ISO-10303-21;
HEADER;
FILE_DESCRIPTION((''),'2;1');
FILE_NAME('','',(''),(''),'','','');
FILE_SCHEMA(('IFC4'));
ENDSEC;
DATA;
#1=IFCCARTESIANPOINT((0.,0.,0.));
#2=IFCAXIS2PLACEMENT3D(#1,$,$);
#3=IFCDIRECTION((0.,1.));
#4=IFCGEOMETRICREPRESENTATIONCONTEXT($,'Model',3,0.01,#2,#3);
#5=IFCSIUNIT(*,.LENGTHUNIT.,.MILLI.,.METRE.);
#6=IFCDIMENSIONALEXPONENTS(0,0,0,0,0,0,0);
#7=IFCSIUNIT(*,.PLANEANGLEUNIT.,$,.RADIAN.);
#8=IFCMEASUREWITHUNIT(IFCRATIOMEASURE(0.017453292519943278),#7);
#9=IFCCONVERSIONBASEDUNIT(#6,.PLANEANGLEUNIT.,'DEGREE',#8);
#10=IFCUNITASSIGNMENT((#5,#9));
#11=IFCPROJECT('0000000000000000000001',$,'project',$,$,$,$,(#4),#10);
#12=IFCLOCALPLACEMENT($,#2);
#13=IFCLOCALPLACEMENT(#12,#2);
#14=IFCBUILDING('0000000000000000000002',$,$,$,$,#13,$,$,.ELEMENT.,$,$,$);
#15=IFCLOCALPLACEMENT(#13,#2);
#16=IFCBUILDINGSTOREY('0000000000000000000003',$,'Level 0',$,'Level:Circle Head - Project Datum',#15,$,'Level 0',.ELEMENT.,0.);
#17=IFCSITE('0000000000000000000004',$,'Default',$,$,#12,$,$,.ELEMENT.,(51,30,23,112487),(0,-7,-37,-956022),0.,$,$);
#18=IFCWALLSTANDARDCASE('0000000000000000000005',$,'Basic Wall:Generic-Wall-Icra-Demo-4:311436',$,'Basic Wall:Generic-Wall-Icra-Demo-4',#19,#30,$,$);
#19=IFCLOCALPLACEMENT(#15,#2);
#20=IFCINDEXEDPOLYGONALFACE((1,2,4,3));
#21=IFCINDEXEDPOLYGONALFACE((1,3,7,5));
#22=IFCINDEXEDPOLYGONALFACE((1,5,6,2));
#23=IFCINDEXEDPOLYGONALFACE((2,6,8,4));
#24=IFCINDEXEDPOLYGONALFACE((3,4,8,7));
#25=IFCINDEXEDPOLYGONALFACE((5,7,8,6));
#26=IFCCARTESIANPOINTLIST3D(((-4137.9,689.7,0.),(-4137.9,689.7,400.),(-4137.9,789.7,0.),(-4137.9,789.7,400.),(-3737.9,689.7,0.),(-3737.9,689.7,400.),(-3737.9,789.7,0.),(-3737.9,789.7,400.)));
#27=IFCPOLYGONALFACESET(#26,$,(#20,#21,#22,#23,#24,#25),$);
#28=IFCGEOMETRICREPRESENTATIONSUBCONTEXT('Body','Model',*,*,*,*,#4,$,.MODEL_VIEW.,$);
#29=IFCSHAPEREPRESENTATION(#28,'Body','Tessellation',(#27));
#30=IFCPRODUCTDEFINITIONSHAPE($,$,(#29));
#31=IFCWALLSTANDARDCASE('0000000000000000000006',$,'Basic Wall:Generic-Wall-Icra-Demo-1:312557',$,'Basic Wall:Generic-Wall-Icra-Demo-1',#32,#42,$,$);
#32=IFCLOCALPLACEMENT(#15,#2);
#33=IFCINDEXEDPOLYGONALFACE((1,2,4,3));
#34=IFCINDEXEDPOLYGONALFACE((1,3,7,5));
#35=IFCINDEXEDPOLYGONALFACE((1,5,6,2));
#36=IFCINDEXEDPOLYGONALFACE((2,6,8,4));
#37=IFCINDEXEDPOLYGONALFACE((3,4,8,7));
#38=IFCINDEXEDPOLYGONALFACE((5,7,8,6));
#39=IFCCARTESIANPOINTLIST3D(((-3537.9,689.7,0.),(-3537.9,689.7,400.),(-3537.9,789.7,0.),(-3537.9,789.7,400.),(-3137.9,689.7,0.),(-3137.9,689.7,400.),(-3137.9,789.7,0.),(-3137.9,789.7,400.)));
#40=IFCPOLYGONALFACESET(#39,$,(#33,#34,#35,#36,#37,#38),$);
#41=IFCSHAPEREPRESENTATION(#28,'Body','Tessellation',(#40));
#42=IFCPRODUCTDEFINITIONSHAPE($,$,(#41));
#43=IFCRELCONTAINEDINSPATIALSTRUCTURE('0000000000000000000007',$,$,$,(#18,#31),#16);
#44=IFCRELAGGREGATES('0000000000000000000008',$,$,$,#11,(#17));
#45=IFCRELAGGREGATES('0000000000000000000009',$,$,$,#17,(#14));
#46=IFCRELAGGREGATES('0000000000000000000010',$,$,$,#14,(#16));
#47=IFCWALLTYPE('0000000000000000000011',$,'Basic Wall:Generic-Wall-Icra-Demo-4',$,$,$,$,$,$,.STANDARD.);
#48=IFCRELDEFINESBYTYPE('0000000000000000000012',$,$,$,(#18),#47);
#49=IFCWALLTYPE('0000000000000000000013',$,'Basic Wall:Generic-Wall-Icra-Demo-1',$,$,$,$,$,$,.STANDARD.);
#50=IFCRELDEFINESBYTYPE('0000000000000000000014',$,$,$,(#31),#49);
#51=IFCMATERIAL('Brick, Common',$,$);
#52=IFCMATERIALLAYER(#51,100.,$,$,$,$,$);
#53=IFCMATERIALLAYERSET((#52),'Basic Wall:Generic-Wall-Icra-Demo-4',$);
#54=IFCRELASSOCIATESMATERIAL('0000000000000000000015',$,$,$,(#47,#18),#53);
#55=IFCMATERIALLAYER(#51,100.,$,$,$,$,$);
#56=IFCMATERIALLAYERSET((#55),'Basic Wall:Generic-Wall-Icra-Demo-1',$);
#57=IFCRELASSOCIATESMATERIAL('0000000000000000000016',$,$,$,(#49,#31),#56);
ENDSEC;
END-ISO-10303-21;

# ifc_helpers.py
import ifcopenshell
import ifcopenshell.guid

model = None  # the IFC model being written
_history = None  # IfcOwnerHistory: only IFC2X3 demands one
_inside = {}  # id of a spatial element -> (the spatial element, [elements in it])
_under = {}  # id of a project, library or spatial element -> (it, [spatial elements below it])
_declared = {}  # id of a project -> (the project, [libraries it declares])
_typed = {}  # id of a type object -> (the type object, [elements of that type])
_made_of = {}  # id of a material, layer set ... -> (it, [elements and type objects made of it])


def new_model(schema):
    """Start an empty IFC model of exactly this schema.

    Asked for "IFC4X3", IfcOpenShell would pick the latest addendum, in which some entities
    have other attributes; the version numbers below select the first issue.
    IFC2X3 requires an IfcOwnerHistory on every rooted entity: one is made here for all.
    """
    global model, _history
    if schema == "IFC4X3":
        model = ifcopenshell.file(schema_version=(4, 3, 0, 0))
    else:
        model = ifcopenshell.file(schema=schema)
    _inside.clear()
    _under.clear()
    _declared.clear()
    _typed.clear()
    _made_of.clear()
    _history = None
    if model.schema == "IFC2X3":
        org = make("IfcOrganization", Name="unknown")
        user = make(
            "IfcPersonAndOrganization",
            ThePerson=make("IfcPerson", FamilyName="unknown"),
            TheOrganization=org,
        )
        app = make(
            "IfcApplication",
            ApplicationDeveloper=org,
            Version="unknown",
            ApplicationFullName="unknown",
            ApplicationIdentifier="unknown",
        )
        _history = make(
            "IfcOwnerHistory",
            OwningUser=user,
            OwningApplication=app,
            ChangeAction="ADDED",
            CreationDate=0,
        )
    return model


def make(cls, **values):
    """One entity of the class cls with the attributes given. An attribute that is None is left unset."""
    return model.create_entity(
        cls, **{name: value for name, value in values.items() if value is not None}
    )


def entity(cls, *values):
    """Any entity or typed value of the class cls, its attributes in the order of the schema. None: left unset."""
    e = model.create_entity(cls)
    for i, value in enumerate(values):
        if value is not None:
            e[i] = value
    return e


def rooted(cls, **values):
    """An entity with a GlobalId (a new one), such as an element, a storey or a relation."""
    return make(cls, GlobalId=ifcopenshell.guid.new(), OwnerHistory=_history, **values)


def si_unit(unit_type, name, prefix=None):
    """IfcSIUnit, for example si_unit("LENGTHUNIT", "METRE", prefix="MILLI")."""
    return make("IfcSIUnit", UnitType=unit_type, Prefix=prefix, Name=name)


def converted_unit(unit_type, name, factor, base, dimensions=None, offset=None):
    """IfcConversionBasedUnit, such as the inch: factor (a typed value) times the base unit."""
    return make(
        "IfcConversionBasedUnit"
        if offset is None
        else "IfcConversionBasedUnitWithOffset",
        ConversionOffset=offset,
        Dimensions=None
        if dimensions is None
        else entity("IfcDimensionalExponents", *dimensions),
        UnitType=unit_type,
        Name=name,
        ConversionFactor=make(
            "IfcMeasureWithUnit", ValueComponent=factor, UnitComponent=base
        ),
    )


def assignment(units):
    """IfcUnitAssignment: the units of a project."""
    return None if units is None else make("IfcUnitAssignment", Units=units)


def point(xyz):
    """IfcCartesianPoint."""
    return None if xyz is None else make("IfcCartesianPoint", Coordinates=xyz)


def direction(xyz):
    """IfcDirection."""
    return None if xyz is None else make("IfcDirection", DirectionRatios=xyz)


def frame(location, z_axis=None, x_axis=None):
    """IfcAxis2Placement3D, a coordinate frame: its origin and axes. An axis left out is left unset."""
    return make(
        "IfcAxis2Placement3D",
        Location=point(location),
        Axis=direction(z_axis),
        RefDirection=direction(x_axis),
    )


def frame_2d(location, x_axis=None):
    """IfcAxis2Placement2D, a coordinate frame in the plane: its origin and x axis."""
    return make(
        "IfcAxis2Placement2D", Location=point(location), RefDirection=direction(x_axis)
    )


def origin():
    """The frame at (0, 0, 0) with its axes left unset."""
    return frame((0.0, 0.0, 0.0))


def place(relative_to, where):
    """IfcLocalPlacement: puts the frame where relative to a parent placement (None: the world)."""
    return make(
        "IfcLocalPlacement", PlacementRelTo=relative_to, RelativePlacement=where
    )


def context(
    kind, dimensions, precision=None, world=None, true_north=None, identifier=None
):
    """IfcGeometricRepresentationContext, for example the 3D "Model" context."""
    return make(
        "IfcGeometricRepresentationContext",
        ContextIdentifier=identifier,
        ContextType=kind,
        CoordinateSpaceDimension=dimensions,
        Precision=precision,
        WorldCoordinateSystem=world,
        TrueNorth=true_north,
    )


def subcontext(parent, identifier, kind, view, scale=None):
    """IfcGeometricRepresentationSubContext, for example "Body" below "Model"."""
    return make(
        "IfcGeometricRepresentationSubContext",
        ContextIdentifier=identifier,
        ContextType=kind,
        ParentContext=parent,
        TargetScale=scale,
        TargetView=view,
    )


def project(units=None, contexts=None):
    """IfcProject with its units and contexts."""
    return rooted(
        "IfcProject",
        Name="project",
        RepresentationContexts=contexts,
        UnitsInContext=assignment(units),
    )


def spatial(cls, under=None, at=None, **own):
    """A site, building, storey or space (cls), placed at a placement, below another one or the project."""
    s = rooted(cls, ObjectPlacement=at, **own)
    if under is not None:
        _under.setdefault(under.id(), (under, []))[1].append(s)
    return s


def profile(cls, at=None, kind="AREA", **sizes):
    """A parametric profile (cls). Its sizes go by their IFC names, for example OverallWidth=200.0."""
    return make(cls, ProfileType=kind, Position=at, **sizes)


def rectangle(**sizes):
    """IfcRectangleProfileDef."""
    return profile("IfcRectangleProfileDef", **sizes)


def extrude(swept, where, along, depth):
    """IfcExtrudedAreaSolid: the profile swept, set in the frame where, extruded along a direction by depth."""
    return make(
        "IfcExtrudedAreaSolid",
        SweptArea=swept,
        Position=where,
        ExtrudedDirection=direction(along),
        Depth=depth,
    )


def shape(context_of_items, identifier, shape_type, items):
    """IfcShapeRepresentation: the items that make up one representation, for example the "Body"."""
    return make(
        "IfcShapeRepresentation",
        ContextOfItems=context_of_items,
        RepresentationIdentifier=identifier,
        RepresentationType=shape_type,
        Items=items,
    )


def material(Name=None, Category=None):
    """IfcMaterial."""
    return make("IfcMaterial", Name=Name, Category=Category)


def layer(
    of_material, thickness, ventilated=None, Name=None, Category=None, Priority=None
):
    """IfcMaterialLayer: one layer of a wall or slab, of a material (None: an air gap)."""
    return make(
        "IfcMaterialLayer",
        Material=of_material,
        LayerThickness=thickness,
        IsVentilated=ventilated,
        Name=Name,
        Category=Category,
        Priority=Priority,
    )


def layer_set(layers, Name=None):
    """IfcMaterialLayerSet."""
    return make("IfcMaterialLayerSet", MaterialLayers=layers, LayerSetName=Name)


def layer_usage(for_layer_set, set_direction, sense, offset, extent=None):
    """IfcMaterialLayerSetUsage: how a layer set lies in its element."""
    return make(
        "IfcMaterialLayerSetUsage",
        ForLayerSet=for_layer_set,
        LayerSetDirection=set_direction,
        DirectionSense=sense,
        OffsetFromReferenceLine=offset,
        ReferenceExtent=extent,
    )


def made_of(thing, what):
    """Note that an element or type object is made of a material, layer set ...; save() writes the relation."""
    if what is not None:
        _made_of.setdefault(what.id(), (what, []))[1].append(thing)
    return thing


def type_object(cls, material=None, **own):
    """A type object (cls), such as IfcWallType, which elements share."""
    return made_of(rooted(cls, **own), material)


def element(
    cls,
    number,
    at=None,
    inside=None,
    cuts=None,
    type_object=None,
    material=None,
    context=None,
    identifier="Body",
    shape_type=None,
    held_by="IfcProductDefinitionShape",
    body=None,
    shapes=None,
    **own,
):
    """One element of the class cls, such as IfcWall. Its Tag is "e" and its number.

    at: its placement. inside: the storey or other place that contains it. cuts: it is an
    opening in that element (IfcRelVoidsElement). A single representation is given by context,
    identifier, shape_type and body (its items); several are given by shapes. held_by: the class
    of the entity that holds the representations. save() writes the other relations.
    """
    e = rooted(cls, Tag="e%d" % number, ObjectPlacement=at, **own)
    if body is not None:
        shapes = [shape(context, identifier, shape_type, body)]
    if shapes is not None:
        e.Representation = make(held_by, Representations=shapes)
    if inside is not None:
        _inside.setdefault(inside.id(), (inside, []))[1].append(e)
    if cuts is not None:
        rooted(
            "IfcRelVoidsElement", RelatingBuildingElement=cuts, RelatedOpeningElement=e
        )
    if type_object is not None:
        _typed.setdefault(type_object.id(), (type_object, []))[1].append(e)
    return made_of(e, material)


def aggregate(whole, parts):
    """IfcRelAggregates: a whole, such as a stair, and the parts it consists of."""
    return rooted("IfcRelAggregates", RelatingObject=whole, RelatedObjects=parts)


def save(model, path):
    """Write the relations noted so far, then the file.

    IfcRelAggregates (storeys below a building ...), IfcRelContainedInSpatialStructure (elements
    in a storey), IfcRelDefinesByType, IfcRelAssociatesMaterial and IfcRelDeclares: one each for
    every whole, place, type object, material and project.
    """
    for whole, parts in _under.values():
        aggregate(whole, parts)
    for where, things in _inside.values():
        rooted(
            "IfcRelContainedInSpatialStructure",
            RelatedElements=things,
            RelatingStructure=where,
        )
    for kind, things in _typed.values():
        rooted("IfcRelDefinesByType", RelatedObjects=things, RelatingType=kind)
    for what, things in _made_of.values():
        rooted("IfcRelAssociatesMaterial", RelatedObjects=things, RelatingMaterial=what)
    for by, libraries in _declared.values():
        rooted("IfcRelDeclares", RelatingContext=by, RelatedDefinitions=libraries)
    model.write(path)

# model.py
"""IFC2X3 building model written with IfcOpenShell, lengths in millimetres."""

from ifc_helpers import new_model, entity, si_unit, converted_unit, direction, frame, frame_2d, origin, place, context, subcontext, project, spatial, rectangle, extrude, material, layer, layer_set, layer_usage, type_object, element, save


model = new_model("IFC2X3")

# Units and contexts
model_context = context("Model", 3, precision=0.01, world=origin(), true_north=direction((0.0, 1.0)))
body_context = subcontext(model_context, "Body", "Model", "MODEL_VIEW")
ifc_project = project(units=[si_unit("LENGTHUNIT", "METRE", prefix="MILLI"), converted_unit("PLANEANGLEUNIT", "DEGREE", entity("IfcRatioMeasure", 0.017453292519943278), si_unit("PLANEANGLEUNIT", "RADIAN"), dimensions=[0, 0, 0, 0, 0, 0, 0])], contexts=[model_context])

# Site, building, storey
site_placement = place(None, origin())
site = spatial("IfcSite", under=ifc_project, at=site_placement, Name="Default", CompositionType="ELEMENT", RefLatitude=(51, 30, 23, 112487), RefLongitude=(0, -7, -37, -956022), RefElevation=0.0)
building_placement = place(site_placement, origin())
building = spatial("IfcBuilding", under=site, at=building_placement, CompositionType="ELEMENT")
storey_placement = place(building_placement, origin())
storey = spatial("IfcBuildingStorey", under=building, at=storey_placement, Name="Level 0", ObjectType="Level:Circle Head - Project Datum", LongName="Level 0", CompositionType="ELEMENT", Elevation=0.0)

# Walls
ifc_material = material(Name="Brick, Common")
ifc_layer_1 = layer(ifc_material, 100.0)
ifc_layer_set_1 = layer_set([ifc_layer_1], Name="Basic Wall:Generic-Wall-Icra-Demo-4")
ifc_layer_usage_1 = layer_usage(ifc_layer_set_1, "AXIS2", "NEGATIVE", 50.0)
wall_type_1 = type_object("IfcWallType", Name="Basic Wall:Generic-Wall-Icra-Demo-4", PredefinedType="STANDARD", material=ifc_layer_set_1)
wall_1_placement = place(storey_placement, frame((-4137.9, 739.7, 0.0)))
element("IfcWallStandardCase", 1, at=wall_1_placement, inside=storey, type_object=wall_type_1, material=ifc_layer_usage_1, Name="Basic Wall:Generic-Wall-Icra-Demo-4:311436", ObjectType="Basic Wall:Generic-Wall-Icra-Demo-4", context=body_context, shape_type="SweptSolid", body=[
    extrude(rectangle(XDim=400.0, YDim=100.0, at=frame_2d((200.0, 0.0), x_axis=(-1.0, 0.0))), origin(), (0.0, 0.0, 1.0), 400.0),
])
ifc_layer_2 = layer(ifc_material, 100.0)
ifc_layer_set_2 = layer_set([ifc_layer_2], Name="Basic Wall:Generic-Wall-Icra-Demo-1")
ifc_layer_usage_2 = layer_usage(ifc_layer_set_2, "AXIS2", "NEGATIVE", 50.0)
wall_type_2 = type_object("IfcWallType", Name="Basic Wall:Generic-Wall-Icra-Demo-1", PredefinedType="STANDARD", material=ifc_layer_set_2)
wall_2_placement = place(storey_placement, frame((-3537.9, 739.7, 0.0)))
element("IfcWallStandardCase", 2, at=wall_2_placement, inside=storey, type_object=wall_type_2, material=ifc_layer_usage_2, Name="Basic Wall:Generic-Wall-Icra-Demo-1:312557", ObjectType="Basic Wall:Generic-Wall-Icra-Demo-1", context=body_context, shape_type="SweptSolid", body=[
    extrude(rectangle(XDim=400.0, YDim=100.0, at=frame_2d((200.0, 0.0), x_axis=(-1.0, 0.0))), origin(), (0.0, 0.0, 1.0), 400.0),
])

save(model, "model.ifc")
